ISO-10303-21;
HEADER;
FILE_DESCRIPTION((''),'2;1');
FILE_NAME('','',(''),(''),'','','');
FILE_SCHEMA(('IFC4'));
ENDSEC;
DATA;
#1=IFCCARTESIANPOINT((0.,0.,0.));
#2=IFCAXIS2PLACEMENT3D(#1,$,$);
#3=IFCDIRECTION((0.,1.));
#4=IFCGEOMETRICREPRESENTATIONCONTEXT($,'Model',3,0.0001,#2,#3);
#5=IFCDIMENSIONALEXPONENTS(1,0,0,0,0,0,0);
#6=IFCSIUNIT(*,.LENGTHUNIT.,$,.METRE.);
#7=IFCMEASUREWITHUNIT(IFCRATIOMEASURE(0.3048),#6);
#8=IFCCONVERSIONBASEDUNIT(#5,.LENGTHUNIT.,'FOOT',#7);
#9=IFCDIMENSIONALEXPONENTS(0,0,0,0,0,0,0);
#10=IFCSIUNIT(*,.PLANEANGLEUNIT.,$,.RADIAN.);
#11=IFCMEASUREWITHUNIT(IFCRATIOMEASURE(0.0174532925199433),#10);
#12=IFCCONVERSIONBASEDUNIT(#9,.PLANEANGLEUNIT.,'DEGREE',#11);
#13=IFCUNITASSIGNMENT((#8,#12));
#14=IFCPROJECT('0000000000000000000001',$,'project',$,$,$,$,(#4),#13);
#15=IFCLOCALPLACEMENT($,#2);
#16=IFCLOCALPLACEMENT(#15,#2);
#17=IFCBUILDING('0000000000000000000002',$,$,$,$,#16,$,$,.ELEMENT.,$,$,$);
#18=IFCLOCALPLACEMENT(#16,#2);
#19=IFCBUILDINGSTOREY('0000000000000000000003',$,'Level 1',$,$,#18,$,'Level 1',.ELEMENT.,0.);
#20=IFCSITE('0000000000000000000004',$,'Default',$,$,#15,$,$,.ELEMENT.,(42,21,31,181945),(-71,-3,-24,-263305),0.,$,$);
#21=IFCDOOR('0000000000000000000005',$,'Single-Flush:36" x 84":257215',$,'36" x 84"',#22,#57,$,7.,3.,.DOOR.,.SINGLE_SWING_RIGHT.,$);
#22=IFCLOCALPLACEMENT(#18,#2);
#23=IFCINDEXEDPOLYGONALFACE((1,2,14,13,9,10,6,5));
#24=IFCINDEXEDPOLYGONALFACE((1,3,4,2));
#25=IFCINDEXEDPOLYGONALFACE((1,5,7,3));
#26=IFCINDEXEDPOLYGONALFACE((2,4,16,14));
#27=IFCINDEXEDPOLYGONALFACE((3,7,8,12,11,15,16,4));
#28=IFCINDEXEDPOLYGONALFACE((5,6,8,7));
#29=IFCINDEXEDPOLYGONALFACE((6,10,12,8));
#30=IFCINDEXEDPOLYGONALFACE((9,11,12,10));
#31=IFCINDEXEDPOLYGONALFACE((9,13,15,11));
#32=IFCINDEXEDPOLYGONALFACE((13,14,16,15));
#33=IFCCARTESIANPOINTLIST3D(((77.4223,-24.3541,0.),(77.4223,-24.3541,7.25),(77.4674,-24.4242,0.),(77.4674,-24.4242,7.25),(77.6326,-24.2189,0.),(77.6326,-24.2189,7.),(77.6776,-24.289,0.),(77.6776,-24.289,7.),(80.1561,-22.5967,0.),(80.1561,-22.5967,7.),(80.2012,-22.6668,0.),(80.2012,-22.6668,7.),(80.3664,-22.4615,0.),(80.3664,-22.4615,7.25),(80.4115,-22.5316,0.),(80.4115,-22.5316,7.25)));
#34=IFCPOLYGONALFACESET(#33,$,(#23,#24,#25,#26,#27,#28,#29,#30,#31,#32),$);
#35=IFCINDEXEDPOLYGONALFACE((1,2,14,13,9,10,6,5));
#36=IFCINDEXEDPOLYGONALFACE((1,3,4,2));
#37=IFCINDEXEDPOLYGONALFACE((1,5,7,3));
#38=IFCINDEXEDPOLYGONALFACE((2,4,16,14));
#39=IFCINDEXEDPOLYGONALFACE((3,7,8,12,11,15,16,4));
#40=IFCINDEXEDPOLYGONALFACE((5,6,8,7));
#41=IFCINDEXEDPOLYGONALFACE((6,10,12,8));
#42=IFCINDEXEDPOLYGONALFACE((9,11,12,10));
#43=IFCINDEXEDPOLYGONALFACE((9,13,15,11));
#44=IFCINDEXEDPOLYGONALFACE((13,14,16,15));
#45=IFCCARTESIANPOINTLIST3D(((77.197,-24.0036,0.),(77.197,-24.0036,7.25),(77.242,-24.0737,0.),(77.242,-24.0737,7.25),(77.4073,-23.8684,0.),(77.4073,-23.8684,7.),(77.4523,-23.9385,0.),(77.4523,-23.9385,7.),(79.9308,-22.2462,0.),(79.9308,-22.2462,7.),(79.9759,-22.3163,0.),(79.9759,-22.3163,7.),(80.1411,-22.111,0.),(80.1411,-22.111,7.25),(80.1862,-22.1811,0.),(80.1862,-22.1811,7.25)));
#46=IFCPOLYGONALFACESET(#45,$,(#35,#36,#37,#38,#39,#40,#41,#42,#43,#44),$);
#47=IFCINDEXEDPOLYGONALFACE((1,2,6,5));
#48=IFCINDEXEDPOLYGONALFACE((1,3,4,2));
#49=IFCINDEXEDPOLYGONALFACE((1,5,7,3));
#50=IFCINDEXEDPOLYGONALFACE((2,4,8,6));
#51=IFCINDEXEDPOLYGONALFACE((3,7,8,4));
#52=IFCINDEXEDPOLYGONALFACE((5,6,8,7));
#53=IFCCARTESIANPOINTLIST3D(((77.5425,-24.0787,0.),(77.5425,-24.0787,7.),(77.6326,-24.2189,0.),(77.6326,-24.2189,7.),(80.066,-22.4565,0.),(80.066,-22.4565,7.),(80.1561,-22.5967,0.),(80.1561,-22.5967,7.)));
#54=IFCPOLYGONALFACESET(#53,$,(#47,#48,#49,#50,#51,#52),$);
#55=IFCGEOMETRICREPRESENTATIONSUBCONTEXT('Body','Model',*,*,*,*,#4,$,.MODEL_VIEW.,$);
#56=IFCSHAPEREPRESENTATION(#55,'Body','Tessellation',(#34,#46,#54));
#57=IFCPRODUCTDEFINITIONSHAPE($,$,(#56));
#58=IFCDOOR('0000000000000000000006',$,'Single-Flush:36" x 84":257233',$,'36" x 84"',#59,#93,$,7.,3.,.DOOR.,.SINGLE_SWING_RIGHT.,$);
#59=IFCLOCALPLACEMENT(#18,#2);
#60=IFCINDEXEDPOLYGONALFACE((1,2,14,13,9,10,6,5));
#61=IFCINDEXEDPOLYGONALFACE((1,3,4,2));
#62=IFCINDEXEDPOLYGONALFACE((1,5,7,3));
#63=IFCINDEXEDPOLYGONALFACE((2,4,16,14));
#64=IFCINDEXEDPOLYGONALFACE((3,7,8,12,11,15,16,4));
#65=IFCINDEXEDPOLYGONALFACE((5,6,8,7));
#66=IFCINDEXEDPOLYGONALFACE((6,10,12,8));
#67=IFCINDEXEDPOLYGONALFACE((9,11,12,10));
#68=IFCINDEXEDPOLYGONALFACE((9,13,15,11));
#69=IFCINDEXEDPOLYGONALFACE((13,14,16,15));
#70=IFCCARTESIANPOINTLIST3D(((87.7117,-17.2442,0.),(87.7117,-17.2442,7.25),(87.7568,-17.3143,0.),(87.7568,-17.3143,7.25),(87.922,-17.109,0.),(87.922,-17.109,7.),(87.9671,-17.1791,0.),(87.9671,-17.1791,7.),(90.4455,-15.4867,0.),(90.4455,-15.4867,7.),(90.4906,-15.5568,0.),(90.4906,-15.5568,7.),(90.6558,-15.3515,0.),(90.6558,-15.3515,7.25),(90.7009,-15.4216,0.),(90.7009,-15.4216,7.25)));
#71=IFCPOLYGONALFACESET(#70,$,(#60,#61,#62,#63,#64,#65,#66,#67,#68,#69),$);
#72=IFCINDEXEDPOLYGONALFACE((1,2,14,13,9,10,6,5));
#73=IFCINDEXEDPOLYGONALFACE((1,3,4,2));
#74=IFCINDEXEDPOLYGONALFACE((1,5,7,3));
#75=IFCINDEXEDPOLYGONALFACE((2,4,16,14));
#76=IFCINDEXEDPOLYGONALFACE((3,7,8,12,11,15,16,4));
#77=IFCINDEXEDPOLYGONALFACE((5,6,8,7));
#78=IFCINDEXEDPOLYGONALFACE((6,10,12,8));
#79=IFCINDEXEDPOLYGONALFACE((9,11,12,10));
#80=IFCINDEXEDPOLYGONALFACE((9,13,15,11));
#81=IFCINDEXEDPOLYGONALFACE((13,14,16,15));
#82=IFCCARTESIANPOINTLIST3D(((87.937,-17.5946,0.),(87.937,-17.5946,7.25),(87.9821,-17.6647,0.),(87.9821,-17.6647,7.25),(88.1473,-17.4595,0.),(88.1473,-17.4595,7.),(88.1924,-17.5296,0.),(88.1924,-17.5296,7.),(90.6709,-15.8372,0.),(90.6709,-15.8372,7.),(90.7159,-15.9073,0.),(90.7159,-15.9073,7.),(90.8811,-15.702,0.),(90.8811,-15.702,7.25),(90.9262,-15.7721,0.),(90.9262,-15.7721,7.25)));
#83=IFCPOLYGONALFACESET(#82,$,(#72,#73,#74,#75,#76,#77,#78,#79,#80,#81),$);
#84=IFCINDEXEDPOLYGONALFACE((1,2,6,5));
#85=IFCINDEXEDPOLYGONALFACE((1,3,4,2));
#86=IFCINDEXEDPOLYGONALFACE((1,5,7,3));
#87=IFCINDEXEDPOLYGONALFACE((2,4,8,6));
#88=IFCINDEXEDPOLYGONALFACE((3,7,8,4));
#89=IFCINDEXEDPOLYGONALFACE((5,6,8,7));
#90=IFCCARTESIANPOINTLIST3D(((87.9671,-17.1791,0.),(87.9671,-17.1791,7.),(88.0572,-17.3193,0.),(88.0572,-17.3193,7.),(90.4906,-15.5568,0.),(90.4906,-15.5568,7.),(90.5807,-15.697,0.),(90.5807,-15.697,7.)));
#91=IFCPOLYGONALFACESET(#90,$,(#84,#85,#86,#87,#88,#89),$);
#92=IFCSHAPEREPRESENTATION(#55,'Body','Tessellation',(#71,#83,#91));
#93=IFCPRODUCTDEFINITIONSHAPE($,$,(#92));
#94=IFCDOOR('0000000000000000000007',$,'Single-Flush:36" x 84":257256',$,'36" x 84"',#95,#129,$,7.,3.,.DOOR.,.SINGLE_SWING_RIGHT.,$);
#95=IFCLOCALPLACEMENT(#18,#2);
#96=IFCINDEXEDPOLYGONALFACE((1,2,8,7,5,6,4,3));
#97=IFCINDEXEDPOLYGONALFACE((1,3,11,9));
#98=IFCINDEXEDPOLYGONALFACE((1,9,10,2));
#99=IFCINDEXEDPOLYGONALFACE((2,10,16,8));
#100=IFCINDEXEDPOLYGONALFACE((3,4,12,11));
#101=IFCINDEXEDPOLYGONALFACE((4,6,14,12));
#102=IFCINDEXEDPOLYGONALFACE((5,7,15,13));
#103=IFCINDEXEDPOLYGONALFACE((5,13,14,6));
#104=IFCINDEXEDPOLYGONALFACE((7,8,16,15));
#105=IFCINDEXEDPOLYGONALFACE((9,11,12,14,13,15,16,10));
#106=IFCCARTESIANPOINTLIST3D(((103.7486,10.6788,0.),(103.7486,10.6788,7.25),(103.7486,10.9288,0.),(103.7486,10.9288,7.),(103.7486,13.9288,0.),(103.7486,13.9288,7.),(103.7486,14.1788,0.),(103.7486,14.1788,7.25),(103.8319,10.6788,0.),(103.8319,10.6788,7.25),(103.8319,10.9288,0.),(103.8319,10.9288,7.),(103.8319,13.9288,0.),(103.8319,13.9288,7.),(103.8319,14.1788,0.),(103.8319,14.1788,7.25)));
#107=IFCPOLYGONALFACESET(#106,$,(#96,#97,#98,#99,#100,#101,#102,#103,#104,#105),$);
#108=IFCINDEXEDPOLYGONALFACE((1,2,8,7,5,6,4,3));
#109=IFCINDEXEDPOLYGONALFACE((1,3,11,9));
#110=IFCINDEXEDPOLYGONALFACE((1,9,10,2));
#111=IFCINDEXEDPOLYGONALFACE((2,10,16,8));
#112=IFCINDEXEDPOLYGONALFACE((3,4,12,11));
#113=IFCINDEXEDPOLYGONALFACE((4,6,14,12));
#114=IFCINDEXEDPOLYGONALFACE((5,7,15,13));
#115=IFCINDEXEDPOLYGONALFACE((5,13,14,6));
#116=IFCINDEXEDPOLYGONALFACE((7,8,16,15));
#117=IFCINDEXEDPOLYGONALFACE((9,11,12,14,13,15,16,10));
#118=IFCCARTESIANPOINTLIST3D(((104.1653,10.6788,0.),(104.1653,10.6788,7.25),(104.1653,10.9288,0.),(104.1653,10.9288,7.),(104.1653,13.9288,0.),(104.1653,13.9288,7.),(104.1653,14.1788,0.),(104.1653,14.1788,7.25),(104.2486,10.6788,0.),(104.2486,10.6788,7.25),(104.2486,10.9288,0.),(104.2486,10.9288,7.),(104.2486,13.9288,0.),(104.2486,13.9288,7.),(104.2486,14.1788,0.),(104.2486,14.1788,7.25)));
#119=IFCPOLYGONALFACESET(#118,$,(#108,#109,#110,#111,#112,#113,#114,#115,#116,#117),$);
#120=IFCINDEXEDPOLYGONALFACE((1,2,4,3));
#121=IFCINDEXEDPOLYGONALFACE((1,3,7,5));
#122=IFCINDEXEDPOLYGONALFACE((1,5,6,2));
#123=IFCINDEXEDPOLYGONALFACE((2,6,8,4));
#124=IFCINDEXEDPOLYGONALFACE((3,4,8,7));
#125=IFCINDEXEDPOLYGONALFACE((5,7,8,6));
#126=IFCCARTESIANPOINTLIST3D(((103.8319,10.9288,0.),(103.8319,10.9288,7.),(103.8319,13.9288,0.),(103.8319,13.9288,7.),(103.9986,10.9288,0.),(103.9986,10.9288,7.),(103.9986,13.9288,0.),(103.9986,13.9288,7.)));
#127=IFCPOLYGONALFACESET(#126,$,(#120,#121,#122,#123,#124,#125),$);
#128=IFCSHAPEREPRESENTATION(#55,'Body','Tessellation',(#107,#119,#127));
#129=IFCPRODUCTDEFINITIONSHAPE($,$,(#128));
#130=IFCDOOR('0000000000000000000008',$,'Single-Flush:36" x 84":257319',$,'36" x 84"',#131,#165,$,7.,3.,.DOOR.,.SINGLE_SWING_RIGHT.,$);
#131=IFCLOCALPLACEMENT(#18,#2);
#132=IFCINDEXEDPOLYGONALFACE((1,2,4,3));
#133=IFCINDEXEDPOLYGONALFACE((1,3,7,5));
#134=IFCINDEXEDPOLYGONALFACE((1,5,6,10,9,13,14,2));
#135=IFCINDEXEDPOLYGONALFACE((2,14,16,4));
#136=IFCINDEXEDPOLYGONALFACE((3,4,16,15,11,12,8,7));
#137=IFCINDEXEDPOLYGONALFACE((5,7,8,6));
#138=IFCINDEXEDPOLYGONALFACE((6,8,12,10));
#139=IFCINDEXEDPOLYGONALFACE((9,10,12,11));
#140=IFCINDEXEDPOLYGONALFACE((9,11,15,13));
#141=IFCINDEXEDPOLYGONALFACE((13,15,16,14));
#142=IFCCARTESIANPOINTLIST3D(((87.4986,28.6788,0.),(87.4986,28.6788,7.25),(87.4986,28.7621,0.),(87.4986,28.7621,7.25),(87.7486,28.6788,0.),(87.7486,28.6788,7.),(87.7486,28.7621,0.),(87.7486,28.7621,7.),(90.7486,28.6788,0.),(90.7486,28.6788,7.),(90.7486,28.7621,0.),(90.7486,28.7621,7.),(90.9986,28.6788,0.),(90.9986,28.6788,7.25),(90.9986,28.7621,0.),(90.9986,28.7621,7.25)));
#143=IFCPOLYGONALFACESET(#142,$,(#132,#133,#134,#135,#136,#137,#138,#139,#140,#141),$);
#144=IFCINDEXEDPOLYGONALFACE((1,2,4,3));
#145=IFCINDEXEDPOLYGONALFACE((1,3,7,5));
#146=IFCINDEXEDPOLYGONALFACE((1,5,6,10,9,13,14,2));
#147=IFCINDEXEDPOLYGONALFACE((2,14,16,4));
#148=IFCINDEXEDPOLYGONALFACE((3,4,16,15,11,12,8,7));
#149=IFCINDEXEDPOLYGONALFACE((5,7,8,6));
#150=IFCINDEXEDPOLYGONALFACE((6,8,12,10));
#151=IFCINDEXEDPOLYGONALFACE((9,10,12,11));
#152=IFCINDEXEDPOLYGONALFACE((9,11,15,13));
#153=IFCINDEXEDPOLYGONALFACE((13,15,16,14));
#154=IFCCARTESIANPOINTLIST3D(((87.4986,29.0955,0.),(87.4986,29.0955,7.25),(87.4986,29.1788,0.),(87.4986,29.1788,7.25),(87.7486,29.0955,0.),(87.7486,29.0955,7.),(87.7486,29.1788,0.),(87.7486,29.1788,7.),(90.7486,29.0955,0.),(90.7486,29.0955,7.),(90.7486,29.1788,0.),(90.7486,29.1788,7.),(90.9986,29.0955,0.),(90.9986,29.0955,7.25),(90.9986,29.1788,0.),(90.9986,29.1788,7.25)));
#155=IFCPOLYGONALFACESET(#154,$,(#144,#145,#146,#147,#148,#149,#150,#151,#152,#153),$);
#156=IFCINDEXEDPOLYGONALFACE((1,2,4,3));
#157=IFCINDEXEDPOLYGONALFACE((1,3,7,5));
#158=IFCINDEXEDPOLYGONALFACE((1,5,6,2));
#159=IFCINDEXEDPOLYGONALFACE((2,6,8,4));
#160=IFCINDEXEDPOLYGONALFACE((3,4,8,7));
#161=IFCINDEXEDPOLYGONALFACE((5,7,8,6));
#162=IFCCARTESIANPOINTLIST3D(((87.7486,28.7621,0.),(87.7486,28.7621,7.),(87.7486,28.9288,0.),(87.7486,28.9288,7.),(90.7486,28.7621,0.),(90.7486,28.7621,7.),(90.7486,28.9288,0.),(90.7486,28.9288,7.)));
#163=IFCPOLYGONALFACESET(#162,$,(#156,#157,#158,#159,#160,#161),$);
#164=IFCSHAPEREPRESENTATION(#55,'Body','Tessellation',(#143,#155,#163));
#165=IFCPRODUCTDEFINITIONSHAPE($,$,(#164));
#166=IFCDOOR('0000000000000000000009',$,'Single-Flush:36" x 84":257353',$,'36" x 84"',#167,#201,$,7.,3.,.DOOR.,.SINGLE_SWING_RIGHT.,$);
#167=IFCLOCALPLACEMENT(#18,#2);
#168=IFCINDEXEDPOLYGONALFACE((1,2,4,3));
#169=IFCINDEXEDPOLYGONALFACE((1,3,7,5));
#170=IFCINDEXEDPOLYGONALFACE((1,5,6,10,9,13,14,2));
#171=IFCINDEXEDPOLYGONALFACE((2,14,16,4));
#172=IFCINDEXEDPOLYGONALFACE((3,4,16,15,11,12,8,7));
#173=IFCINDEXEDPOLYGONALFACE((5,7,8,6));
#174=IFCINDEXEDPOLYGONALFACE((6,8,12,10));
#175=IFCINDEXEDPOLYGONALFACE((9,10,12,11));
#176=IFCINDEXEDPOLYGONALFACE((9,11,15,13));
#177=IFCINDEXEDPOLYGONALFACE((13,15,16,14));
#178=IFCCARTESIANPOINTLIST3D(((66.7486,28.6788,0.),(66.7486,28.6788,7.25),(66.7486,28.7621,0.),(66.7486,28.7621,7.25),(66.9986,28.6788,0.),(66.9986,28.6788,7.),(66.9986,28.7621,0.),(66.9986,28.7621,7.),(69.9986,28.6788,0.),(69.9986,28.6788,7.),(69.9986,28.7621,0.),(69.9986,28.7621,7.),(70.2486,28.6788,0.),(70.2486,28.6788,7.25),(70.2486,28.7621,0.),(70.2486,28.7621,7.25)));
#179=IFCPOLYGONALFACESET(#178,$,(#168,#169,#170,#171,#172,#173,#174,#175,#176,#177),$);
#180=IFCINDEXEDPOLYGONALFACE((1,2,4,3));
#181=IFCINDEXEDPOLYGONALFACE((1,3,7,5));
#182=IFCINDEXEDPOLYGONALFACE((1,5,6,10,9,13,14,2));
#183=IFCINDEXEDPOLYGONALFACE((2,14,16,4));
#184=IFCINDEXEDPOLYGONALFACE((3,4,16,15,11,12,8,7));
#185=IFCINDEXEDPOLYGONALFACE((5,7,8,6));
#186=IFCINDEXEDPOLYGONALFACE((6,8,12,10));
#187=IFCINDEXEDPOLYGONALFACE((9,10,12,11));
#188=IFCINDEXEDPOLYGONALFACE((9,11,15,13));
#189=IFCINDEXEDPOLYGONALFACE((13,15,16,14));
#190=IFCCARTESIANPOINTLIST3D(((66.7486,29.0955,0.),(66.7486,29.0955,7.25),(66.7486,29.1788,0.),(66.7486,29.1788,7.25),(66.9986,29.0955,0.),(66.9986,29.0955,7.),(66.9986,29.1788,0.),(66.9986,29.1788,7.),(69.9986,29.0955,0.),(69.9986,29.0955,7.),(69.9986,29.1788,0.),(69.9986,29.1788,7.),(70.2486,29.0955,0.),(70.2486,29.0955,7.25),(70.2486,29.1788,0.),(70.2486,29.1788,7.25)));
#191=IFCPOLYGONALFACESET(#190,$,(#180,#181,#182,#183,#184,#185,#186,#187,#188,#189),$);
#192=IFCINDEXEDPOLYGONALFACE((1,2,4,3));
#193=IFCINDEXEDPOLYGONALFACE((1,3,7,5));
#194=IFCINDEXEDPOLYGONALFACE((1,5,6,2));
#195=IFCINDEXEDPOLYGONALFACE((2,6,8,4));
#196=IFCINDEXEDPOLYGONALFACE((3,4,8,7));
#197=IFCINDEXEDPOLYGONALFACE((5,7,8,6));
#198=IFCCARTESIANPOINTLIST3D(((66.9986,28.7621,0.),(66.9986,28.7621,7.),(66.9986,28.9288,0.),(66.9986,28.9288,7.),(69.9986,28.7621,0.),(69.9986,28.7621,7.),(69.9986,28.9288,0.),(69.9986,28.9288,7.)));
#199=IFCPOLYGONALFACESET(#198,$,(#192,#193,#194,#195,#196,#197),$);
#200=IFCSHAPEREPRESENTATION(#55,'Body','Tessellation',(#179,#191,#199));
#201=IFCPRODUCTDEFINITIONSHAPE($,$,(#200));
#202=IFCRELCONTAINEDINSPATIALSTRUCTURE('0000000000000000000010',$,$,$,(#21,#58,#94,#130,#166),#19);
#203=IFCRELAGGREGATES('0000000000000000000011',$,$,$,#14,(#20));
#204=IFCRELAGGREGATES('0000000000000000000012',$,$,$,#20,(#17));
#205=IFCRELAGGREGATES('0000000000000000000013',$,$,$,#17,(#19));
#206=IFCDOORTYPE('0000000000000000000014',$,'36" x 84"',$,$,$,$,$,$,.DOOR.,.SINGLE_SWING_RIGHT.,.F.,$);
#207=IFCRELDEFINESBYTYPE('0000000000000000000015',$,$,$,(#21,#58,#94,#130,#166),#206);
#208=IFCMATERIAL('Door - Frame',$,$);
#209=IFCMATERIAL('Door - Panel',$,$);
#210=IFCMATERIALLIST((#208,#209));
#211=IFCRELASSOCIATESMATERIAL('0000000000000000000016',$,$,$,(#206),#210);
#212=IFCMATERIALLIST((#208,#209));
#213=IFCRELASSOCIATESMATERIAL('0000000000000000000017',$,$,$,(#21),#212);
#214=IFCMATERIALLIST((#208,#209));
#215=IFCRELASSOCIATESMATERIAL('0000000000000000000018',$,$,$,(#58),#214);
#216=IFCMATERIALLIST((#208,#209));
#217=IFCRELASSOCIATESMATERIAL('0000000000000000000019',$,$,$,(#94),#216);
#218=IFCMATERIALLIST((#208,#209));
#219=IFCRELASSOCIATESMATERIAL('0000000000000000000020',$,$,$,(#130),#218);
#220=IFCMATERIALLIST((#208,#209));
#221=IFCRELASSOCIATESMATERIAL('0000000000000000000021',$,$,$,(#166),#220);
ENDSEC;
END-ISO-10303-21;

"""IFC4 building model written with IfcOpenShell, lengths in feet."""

from ifc_helpers import new_model, entity, si_unit, converted_unit, direction, frame, frame_2d, origin, place, context, subcontext, project, spatial, polyline, rectangle, outline, extrude, source, transform, mapped, material, material_list, type_object, type_shapes, element, save


model = new_model("IFC4")

# Units and contexts
model_context = context("Model", 3, precision=0.0001, world=origin(), true_north=direction((0.0, 1.0)))
body_context = subcontext(model_context, "Body", "Model", "MODEL_VIEW")
ifc_project = project(units=[converted_unit("LENGTHUNIT", "FOOT", entity("IfcRatioMeasure", 0.3048), si_unit("LENGTHUNIT", "METRE"), dimensions=[1, 0, 0, 0, 0, 0, 0]), converted_unit("PLANEANGLEUNIT", "DEGREE", entity("IfcRatioMeasure", 0.0174532925199433), si_unit("PLANEANGLEUNIT", "RADIAN"), dimensions=[0, 0, 0, 0, 0, 0, 0])], contexts=[model_context])

# Site, building, storey
site_placement = place(None, origin())
site = spatial("IfcSite", under=ifc_project, at=site_placement, Name="Default", CompositionType="ELEMENT", RefLatitude=(42, 21, 31, 181945), RefLongitude=(-71, -3, -24, -263305), RefElevation=0.0)
building_placement = place(site_placement, origin())
building = spatial("IfcBuilding", under=site, at=building_placement, CompositionType="ELEMENT")
storey_placement = place(building_placement, origin())
storey = spatial("IfcBuildingStorey", under=building, at=storey_placement, Name="Level 1", LongName="Level 1", CompositionType="ELEMENT", Elevation=0.0)

# Shared definitions
placement_1 = place(storey_placement, frame((-0.1681, 28.9288, 0.0)))
placement_2 = place(storey_placement, frame((103.9574, -7.0977, 0.0), z_axis=(0.0, 0.0, 1.0), x_axis=(-0.841178, -0.540758, 0.0)))

# Doors
ifc_material_1 = material(Name="Door - Frame")
ifc_material_2 = material(Name="Door - Panel")
ifc_material_list_1 = material_list([ifc_material_1, ifc_material_2])
door_type = type_object("IfcDoorType", Name="36\" x 84\"", OperationType="SINGLE_SWING_RIGHT", ParameterTakesPrecedence=False, PredefinedType="DOOR", material=ifc_material_list_1)
shared_shape_1 = source(origin(), body_context, "Body", "SweptSolid", [
    extrude(outline(polyline([(-1.75, -3.6875), (1.75, -3.6875), (1.75, 3.5625), (1.5, 3.5625), (1.5, -3.4375), (-1.5, -3.4375), (-1.5, 3.5625), (-1.75, 3.5625), (-1.75, -3.6875)])), frame((1.5, 0.3333, 3.5625), z_axis=(0.0, 1.0, 0.0), x_axis=(1.0, 0.0, 0.0)), (0.0, 0.0, 1.0), 0.0833),
    extrude(outline(polyline([(-3.6875, -1.75), (3.5625, -1.75), (3.5625, -1.5), (-3.4375, -1.5), (-3.4375, 1.5), (3.5625, 1.5), (3.5625, 1.75), (-3.6875, 1.75), (-3.6875, -1.75)])), frame((1.5, -0.0833, 3.5625), z_axis=(0.0, 1.0, 0.0), x_axis=(0.0, 0.0, -1.0)), (0.0, 0.0, 1.0), 0.0833),
    extrude(rectangle(XDim=0.1667, YDim=3.0, at=frame_2d((0.0, 0.0), x_axis=(1.0, 0.0))), frame((1.5, 0.25, 0.0), z_axis=(0.0, 0.0, 1.0), x_axis=(0.0, 1.0, 0.0)), (0.0, 0.0, 1.0), 7.0),
])
type_shapes(door_type, [shared_shape_1])
ifc_material_list_2 = material_list([ifc_material_1, ifc_material_2])
placement_3 = place(placement_2, frame((28.4023, -0.1667, 0.0)))
door_1_placement = place(placement_3, origin())
element("IfcDoor", 1, at=door_1_placement, inside=storey, type_object=door_type, material=ifc_material_list_2, Name="Single-Flush:36\" x 84\":257215", ObjectType="36\" x 84\"", OperationType="SINGLE_SWING_RIGHT", OverallHeight=7.0, OverallWidth=3.0, PredefinedType="DOOR", context=body_context, shape_type="MappedRepresentation", body=[
    mapped(shared_shape_1, transform((0.0, 0.0, 0.0), scale=1.0)),
])
ifc_material_list_3 = material_list([ifc_material_1, ifc_material_2])
placement_4 = place(placement_2, frame((18.9023, 0.1667, 0.0)))
door_2_placement = place(placement_4, frame((0.0, 0.0, 0.0), z_axis=(0.0, 0.0, 1.0), x_axis=(-1.0, 0.0, 0.0)))
element("IfcDoor", 2, at=door_2_placement, inside=storey, type_object=door_type, material=ifc_material_list_3, Name="Single-Flush:36\" x 84\":257233", ObjectType="36\" x 84\"", OperationType="SINGLE_SWING_RIGHT", OverallHeight=7.0, OverallWidth=3.0, PredefinedType="DOOR", context=body_context, shape_type="MappedRepresentation", body=[
    mapped(shared_shape_1, transform((0.0, 0.0, 0.0), scale=1.0)),
])
ifc_material_list_4 = material_list([ifc_material_1, ifc_material_2])
placement_5 = place(storey_placement, frame((103.9986, -6.9045, 0.0), z_axis=(0.0, 0.0, 1.0), x_axis=(0.0, 1.0, 0.0)))
placement_6 = place(placement_5, frame((17.8333, -0.1667, 0.0)))
door_3_placement = place(placement_6, origin())
element("IfcDoor", 3, at=door_3_placement, inside=storey, type_object=door_type, material=ifc_material_list_4, Name="Single-Flush:36\" x 84\":257256", ObjectType="36\" x 84\"", OperationType="SINGLE_SWING_RIGHT", OverallHeight=7.0, OverallWidth=3.0, PredefinedType="DOOR", context=body_context, shape_type="MappedRepresentation", body=[
    mapped(shared_shape_1, transform((0.0, 0.0, 0.0), scale=1.0)),
])
ifc_material_list_5 = material_list([ifc_material_1, ifc_material_2])
placement_7 = place(placement_1, frame((90.9167, 0.1667, 0.0)))
door_4_placement = place(placement_7, frame((0.0, 0.0, 0.0), z_axis=(0.0, 0.0, 1.0), x_axis=(-1.0, 0.0, 0.0)))
element("IfcDoor", 4, at=door_4_placement, inside=storey, type_object=door_type, material=ifc_material_list_5, Name="Single-Flush:36\" x 84\":257319", ObjectType="36\" x 84\"", OperationType="SINGLE_SWING_RIGHT", OverallHeight=7.0, OverallWidth=3.0, PredefinedType="DOOR", context=body_context, shape_type="MappedRepresentation", body=[
    mapped(shared_shape_1, transform((0.0, 0.0, 0.0), scale=1.0)),
])
ifc_material_list_6 = material_list([ifc_material_1, ifc_material_2])
placement_8 = place(placement_1, frame((70.1667, 0.1667, 0.0)))
door_5_placement = place(placement_8, frame((0.0, 0.0, 0.0), z_axis=(0.0, 0.0, 1.0), x_axis=(-1.0, 0.0, 0.0)))
element("IfcDoor", 5, at=door_5_placement, inside=storey, type_object=door_type, material=ifc_material_list_6, Name="Single-Flush:36\" x 84\":257353", ObjectType="36\" x 84\"", OperationType="SINGLE_SWING_RIGHT", OverallHeight=7.0, OverallWidth=3.0, PredefinedType="DOOR", context=body_context, shape_type="MappedRepresentation", body=[
    mapped(shared_shape_1, transform((0.0, 0.0, 0.0), scale=1.0)),
])

save(model, "model.ifc")
